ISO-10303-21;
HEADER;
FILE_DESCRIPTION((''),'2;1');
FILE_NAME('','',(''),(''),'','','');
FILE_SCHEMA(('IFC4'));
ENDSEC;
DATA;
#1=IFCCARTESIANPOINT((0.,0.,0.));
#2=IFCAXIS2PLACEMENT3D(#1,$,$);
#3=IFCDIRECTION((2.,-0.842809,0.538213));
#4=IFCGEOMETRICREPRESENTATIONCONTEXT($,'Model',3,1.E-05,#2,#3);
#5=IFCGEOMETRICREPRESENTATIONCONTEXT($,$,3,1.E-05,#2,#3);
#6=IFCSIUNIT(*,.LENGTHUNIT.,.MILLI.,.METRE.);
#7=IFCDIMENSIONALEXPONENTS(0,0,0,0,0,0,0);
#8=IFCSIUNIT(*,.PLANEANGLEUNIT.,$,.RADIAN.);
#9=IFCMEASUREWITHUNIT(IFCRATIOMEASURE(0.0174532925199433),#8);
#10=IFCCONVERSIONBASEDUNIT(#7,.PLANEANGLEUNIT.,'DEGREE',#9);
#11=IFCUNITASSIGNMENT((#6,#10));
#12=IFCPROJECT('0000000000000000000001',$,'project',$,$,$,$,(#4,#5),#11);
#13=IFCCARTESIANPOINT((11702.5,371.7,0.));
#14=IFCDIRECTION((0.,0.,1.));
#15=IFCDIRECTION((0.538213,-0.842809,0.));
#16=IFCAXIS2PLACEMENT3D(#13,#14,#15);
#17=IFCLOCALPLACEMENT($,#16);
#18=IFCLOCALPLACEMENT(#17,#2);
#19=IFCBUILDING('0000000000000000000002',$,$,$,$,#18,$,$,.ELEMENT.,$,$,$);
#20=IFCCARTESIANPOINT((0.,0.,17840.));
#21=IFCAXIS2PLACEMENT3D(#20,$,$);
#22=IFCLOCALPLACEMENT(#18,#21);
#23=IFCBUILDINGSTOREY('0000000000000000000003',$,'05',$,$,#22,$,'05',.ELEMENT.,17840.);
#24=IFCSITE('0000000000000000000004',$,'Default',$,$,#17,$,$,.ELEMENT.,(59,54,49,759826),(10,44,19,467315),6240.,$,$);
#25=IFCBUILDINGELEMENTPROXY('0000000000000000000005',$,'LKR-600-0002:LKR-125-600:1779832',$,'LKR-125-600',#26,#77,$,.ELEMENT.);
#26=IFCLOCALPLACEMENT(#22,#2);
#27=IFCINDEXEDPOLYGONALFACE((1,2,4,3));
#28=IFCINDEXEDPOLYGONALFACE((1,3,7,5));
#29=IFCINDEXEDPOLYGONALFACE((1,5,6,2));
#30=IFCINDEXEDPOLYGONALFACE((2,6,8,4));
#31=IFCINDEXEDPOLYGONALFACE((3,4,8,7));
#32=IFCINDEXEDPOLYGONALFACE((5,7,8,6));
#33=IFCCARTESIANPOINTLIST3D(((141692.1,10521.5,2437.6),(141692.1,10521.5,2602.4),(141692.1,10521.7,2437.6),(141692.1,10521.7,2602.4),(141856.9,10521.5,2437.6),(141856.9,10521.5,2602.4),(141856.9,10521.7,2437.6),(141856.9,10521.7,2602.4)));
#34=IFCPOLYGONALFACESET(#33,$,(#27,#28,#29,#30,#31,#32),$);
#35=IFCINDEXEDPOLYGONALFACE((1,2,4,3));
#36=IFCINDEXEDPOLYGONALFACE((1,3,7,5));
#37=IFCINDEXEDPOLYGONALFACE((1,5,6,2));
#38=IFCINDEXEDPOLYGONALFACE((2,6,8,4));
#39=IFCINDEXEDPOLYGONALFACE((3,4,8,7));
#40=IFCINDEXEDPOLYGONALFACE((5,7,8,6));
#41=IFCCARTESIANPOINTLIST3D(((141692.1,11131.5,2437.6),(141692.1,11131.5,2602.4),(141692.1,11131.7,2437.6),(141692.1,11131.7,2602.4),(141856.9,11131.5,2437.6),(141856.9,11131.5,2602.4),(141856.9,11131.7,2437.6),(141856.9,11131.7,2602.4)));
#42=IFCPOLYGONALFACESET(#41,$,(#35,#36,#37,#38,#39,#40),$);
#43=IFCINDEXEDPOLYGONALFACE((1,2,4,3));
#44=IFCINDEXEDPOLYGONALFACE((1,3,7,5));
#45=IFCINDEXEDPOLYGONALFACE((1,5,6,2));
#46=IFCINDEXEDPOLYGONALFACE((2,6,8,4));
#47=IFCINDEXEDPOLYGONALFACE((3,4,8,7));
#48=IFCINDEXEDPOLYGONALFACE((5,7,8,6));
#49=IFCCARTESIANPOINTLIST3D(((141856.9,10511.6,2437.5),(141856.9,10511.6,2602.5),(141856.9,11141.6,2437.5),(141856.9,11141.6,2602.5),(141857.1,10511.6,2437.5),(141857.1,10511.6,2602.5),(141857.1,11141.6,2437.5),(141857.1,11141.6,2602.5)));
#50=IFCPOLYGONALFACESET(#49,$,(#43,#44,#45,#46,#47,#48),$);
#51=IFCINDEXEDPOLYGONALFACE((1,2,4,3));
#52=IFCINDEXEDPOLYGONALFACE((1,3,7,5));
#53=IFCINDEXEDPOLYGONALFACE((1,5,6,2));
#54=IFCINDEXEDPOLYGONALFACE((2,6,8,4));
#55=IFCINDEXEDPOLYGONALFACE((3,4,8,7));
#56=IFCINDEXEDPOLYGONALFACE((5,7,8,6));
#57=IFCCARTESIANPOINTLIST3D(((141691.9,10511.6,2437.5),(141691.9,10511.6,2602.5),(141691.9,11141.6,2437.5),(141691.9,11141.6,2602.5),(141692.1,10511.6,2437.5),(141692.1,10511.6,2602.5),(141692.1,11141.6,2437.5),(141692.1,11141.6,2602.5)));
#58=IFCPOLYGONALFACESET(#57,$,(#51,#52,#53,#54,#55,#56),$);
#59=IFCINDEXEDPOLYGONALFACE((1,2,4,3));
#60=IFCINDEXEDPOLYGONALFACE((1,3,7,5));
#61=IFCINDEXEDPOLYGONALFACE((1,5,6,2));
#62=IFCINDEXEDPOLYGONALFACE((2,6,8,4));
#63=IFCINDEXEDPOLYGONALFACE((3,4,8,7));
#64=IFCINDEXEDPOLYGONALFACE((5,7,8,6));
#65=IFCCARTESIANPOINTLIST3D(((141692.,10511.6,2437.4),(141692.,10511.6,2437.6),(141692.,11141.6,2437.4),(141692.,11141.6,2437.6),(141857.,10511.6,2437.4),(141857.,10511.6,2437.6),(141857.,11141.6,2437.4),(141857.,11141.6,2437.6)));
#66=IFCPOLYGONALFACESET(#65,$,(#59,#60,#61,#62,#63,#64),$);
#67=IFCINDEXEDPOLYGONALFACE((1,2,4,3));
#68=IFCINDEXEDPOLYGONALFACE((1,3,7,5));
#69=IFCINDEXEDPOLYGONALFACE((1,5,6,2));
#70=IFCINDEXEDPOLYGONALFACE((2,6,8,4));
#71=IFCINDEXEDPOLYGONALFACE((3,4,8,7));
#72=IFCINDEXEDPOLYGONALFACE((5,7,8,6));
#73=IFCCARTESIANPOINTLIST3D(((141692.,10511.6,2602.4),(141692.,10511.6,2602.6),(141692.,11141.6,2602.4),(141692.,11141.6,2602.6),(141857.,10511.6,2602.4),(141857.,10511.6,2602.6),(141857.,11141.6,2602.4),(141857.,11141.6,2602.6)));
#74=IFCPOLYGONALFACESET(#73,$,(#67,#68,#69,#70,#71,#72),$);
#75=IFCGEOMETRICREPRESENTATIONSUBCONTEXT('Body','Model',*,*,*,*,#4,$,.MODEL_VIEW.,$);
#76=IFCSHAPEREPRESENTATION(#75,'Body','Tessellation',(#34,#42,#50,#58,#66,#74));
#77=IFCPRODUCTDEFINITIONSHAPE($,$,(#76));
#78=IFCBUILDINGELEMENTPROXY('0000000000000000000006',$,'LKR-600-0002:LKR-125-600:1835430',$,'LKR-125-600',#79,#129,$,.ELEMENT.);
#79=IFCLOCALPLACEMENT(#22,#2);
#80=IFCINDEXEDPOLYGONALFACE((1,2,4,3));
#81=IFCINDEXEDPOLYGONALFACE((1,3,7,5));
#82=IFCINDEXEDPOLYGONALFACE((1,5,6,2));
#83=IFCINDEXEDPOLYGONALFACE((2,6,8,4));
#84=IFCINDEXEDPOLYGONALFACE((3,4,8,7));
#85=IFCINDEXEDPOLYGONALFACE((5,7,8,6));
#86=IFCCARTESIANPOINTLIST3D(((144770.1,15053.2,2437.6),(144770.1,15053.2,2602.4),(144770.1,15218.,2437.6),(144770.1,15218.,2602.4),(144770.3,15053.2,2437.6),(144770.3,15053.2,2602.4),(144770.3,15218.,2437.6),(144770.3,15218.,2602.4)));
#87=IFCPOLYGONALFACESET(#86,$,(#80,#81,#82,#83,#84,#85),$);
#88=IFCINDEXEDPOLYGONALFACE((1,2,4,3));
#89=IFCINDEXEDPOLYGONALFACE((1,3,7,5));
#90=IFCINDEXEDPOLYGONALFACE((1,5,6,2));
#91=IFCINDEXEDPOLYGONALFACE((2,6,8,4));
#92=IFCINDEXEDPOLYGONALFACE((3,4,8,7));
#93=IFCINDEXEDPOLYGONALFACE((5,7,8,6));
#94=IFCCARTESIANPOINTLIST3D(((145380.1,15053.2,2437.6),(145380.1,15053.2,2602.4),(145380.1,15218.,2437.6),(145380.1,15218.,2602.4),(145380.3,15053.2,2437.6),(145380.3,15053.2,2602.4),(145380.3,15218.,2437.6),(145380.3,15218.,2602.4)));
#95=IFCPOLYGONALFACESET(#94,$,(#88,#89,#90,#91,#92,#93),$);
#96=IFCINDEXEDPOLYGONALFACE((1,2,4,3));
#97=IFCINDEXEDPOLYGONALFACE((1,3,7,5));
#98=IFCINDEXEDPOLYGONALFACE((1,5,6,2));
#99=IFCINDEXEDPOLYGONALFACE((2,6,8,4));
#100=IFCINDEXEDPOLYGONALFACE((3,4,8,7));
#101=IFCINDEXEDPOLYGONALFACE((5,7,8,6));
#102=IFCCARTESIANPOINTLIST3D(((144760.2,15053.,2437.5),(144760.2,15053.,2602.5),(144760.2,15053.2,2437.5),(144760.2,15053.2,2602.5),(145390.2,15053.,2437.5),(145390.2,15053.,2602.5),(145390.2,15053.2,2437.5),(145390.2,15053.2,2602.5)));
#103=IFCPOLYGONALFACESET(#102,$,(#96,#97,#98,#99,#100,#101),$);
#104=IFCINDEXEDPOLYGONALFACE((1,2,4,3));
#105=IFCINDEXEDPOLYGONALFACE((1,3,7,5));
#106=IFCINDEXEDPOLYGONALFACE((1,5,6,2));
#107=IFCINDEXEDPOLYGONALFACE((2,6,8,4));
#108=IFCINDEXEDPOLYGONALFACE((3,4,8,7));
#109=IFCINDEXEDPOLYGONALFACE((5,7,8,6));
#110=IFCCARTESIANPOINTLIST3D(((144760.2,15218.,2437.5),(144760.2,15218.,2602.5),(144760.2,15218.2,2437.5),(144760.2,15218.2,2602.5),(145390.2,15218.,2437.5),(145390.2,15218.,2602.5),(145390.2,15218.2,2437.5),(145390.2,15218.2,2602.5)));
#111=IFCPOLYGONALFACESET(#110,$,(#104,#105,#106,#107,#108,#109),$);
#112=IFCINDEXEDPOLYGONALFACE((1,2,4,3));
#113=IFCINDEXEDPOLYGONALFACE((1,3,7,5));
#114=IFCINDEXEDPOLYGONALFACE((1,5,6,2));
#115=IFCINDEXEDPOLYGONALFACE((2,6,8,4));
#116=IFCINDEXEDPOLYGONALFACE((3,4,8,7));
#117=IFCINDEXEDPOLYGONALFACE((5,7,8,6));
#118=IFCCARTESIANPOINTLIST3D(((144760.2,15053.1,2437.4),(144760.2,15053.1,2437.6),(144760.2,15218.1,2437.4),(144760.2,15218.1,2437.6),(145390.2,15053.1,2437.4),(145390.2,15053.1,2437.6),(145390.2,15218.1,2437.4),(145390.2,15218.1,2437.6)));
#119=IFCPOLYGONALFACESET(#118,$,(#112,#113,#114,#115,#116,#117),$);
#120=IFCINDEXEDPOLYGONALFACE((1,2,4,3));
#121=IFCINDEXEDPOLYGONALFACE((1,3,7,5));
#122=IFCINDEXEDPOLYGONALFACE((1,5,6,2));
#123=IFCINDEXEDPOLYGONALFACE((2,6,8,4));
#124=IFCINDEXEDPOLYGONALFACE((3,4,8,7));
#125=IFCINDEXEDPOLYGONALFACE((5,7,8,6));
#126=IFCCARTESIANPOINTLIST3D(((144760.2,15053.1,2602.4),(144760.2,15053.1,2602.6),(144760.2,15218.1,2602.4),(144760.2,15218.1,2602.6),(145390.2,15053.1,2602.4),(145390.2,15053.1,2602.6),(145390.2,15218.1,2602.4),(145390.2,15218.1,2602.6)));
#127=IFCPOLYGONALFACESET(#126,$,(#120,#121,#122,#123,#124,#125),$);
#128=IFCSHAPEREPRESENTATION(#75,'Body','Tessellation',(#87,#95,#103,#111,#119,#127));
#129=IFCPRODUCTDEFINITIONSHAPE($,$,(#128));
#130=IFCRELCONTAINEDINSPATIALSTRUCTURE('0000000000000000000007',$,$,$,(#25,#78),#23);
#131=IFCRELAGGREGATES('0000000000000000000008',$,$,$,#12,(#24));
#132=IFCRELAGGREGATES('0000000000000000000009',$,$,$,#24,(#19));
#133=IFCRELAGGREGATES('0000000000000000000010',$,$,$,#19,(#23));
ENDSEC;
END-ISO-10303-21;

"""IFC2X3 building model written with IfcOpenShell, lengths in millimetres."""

from ifc_helpers import new_model, entity, si_unit, converted_unit, direction, frame, frame_2d, origin, place, context, subcontext, project, spatial, rectangle, extrude, source, transform, mapped, element, save


model = new_model("IFC2X3")

# Units and contexts
model_context = context("Model", 3, precision=1e-05, world=origin(), true_north=direction((2.0, -0.842809, 0.538213)))
context_of_model = context(None, 3, precision=1e-05, world=origin(), true_north=direction((2.0, -0.842809, 0.538213)))
body_context = subcontext(model_context, "Body", "Model", "MODEL_VIEW")
ifc_project = project(units=[si_unit("LENGTHUNIT", "METRE", prefix="MILLI"), converted_unit("PLANEANGLEUNIT", "DEGREE", entity("IfcRatioMeasure", 0.0174532925199433), si_unit("PLANEANGLEUNIT", "RADIAN"), dimensions=[0, 0, 0, 0, 0, 0, 0])], contexts=[model_context, context_of_model])

# Site, building, storey
site_placement = place(None, frame((11702.5, 371.7, 0.0), z_axis=(0.0, 0.0, 1.0), x_axis=(0.538213, -0.842809, 0.0)))
site = spatial("IfcSite", under=ifc_project, at=site_placement, Name="Default", CompositionType="ELEMENT", RefLatitude=(59, 54, 49, 759826), RefLongitude=(10, 44, 19, 467315), RefElevation=6240.0)
building_placement = place(site_placement, origin())
building = spatial("IfcBuilding", under=site, at=building_placement, CompositionType="ELEMENT")
storey_placement = place(building_placement, frame((0.0, 0.0, 17840.0)))
storey = spatial("IfcBuildingStorey", under=building, at=storey_placement, Name="05", LongName="05", CompositionType="ELEMENT", Elevation=17840.0)

# Building element proxies
shared_shape_1 = source(origin(), body_context, "Body", "SweptSolid", [
    extrude(rectangle(XDim=0.2, YDim=164.8, at=frame_2d((0.0, 0.0), x_axis=(1.0, 0.0))), frame((305.0, 0.0, -82.4)), (0.0, 0.0, 1.0), 164.8),
    extrude(rectangle(XDim=0.2, YDim=164.8, at=frame_2d((0.0, 0.0), x_axis=(1.0, 0.0))), frame((-305.0, 0.0, -82.4)), (0.0, 0.0, 1.0), 164.8),
    extrude(rectangle(XDim=0.2, YDim=630.0, at=frame_2d((0.0, 0.0), x_axis=(1.0, 0.0))), frame((0.0, 82.5, -82.5), z_axis=(0.0, 0.0, 1.0), x_axis=(0.0, 1.0, 0.0)), (0.0, 0.0, 1.0), 165.0),
    extrude(rectangle(XDim=0.2, YDim=630.0, at=frame_2d((0.0, 0.0), x_axis=(1.0, 0.0))), frame((0.0, -82.5, -82.5), z_axis=(0.0, 0.0, 1.0), x_axis=(0.0, 1.0, 0.0)), (0.0, 0.0, 1.0), 165.0),
    extrude(rectangle(XDim=165.0, YDim=630.0, at=frame_2d((0.0, 0.0), x_axis=(1.0, 0.0))), frame((0.0, 0.0, -82.6), z_axis=(0.0, 0.0, 1.0), x_axis=(0.0, -1.0, 0.0)), (0.0, 0.0, 1.0), 0.2),
    extrude(rectangle(XDim=165.0, YDim=630.0, at=frame_2d((0.0, 0.0), x_axis=(1.0, 0.0))), frame((0.0, 0.0, 82.4), z_axis=(0.0, 0.0, 1.0), x_axis=(0.0, -1.0, 0.0)), (0.0, 0.0, 1.0), 0.2),
])
for number, where, z_axis, x_axis, name in (
    (1, (141774.5, 10826.6, 2520.0), (0.0, 0.0, 1.0), (0.0, -1.0, 0.0), "LKR-600-0002:LKR-125-600:1779832"),
    (2, (145075.2, 15135.6, 2520.0), (0.0, 0.0, 1.0), (-1.0, 0.0, 0.0), "LKR-600-0002:LKR-125-600:1835430"),
):
    element("IfcBuildingElementProxy", number, at=place(storey_placement, frame(where, z_axis=z_axis, x_axis=x_axis)), inside=storey, Name=name, ObjectType="LKR-125-600", CompositionType="ELEMENT", context=body_context, shape_type="MappedRepresentation", body=[
        mapped(shared_shape_1, transform((0.0, 0.0, 0.0), scale=1.0)),
    ])

save(model, "model.ifc")
